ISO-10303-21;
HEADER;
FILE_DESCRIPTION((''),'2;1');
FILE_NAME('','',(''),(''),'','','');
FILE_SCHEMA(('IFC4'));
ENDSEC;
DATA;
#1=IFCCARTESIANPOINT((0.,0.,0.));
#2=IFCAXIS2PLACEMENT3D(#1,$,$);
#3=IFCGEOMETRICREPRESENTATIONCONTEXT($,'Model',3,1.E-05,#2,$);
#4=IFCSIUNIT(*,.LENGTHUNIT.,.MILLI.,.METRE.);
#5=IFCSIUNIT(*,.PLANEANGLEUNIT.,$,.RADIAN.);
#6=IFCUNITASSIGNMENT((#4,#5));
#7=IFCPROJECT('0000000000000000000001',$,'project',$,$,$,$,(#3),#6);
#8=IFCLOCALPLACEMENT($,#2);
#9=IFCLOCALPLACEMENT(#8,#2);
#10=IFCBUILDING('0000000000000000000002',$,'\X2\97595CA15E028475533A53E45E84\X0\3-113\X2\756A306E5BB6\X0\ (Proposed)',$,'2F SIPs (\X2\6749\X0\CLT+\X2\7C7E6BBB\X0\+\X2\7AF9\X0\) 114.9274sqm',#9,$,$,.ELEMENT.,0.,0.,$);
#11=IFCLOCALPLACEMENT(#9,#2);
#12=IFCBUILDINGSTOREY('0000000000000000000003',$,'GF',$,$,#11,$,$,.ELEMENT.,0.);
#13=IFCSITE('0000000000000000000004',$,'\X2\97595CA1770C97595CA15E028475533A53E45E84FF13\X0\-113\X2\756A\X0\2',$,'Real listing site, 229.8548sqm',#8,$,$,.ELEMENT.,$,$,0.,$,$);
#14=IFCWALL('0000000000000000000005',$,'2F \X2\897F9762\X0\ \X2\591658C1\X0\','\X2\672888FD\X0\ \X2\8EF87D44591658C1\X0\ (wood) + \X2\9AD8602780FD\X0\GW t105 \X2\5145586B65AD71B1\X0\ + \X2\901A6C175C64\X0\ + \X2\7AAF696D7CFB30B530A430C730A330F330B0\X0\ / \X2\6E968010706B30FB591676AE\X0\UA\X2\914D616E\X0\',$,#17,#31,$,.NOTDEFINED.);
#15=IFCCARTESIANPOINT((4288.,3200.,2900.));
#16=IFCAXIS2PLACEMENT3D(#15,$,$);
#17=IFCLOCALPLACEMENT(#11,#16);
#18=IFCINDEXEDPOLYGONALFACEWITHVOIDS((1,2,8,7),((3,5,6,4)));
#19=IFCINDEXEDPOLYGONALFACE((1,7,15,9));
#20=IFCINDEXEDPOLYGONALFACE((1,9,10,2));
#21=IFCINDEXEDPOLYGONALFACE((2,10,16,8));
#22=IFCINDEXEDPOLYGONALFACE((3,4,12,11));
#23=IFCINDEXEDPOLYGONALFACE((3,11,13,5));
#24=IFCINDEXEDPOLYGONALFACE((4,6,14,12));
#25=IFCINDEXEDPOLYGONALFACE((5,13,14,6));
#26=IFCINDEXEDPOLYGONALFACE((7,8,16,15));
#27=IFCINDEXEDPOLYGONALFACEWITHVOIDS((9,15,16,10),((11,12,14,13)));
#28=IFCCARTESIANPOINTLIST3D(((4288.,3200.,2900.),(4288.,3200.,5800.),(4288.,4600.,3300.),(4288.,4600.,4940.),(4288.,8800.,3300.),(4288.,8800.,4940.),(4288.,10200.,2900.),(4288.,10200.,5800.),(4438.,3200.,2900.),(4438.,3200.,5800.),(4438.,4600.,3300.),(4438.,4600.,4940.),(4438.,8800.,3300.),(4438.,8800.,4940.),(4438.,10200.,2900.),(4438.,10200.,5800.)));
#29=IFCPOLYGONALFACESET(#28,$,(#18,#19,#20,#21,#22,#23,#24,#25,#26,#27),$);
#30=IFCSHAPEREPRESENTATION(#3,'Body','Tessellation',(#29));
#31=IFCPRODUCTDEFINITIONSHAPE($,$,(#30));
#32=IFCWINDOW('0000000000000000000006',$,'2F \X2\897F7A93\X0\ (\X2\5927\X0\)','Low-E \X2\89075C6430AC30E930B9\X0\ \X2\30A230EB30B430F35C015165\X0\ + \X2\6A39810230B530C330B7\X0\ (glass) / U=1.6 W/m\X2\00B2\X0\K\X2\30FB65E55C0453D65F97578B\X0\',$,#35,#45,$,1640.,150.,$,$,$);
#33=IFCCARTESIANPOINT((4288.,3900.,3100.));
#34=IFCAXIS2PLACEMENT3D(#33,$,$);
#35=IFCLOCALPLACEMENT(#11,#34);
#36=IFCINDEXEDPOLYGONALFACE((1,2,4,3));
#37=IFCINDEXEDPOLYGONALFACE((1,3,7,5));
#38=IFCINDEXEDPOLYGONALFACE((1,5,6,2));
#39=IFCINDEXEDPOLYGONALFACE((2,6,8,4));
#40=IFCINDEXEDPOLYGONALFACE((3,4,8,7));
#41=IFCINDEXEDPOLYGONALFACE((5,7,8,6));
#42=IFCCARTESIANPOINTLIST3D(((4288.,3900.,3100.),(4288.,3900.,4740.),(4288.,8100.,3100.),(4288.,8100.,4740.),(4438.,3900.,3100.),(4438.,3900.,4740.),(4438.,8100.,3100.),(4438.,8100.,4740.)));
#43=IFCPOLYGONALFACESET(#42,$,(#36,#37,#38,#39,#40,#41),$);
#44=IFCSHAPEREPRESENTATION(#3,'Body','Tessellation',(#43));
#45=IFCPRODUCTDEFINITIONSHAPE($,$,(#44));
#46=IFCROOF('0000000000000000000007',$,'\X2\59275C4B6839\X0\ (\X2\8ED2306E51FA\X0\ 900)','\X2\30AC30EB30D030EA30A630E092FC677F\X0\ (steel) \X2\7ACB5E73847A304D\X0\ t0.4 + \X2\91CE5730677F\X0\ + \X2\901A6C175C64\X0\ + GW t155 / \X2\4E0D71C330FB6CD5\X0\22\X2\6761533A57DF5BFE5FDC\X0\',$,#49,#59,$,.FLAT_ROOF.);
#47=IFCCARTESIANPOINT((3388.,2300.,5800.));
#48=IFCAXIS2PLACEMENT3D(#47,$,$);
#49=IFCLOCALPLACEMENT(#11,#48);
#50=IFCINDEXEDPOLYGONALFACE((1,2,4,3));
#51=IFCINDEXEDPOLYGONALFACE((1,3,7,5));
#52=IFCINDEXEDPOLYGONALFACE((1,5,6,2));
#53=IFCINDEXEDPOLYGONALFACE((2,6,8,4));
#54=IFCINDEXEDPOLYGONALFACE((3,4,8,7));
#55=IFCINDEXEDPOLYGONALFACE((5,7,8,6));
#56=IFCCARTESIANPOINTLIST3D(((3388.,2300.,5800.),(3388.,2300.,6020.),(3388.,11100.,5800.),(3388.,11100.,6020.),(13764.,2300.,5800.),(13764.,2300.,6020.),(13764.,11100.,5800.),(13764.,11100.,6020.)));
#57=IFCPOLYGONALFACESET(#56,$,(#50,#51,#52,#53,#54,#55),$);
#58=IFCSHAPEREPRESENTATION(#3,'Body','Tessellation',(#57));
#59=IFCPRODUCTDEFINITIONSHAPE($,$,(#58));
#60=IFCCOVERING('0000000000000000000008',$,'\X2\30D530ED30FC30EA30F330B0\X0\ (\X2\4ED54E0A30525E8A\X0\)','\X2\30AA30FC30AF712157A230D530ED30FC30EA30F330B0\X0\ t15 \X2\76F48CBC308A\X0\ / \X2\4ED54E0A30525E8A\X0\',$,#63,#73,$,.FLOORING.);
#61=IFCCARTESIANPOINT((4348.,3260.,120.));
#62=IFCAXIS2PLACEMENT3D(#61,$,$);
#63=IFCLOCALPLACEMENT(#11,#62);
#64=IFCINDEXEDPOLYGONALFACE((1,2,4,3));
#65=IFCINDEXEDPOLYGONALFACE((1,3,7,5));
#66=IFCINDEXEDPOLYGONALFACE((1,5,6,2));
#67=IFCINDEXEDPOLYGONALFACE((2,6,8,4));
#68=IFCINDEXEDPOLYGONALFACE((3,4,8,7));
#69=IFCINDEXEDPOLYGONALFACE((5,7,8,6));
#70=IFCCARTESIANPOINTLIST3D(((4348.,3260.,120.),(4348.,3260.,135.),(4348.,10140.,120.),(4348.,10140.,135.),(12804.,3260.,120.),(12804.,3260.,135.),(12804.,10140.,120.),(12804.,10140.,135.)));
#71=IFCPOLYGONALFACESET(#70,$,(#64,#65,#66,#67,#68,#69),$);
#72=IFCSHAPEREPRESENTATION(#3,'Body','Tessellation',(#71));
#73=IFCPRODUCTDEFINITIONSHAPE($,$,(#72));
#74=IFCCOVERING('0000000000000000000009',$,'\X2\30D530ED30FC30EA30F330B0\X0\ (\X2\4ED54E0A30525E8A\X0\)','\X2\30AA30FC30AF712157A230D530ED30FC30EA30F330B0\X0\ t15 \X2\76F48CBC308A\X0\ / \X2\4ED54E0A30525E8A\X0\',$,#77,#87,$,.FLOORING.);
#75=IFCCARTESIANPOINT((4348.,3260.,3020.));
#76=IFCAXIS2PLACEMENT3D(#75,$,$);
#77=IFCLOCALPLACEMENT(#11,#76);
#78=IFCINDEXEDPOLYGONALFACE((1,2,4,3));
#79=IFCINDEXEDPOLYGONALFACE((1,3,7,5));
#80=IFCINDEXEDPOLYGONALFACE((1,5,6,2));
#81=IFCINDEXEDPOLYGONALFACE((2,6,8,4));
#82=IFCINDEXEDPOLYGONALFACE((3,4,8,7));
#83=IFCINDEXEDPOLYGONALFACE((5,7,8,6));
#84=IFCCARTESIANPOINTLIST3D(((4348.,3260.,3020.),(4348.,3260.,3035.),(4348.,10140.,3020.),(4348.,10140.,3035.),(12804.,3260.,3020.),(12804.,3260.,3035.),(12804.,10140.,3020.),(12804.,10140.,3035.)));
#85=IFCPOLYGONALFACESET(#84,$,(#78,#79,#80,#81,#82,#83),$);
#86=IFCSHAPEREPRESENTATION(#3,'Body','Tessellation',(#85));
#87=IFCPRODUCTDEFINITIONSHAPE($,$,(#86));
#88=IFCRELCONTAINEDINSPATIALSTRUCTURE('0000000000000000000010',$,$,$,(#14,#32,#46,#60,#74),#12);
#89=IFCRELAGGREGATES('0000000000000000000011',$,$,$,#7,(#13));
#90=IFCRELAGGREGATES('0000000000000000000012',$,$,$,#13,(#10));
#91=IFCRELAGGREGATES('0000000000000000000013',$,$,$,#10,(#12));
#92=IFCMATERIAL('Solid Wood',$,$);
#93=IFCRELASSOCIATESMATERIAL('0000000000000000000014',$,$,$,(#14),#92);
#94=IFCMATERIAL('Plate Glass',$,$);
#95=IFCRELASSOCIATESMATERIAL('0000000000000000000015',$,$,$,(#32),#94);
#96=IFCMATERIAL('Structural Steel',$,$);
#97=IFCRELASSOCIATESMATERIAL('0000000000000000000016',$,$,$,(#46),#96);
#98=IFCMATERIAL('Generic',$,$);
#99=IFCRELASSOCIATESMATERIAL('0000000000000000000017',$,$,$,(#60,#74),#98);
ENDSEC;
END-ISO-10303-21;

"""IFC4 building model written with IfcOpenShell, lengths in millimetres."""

from ifc_helpers import new_model, si_unit, frame, frame_2d, origin, place, context, project, spatial, rectangle, extrude, material, element, fill, save


model = new_model("IFC4")

# Units and contexts
model_context = context("Model", 3, precision=1e-05, world=origin())
ifc_project = project(units=[si_unit("LENGTHUNIT", "METRE", prefix="MILLI"), si_unit("PLANEANGLEUNIT", "RADIAN")], contexts=[model_context])

# Site, building, storey
site_placement = place(None, origin())
site = spatial("IfcSite", under=ifc_project, at=site_placement, Name="静岡県静岡市葵区古庄３-113番2", ObjectType="Real listing site, 229.8548sqm", CompositionType="ELEMENT", RefElevation=0.0)
building_placement = place(site_placement, origin())
building = spatial("IfcBuilding", under=site, at=building_placement, Name="静岡市葵区古庄3-113番の家 (Proposed)", ObjectType="2F SIPs (杉CLT+籾殻+竹) 114.9274sqm", CompositionType="ELEMENT", ElevationOfRefHeight=0.0, ElevationOfTerrain=0.0)
storey_placement = place(building_placement, origin())
storey = spatial("IfcBuildingStorey", under=building, at=storey_placement, Name="GF", CompositionType="ELEMENT", Elevation=0.0)

# Shared definitions
ifc_material_1 = material(Name="Solid Wood")

# Shared definitions
ifc_material_2 = material(Name="Plate Glass")

# Wall, opening, window
wall_1_placement = place(storey_placement, frame((4288.0, 3200.0, 2900.0)))
wall_1 = element("IfcWall", 1, at=wall_1_placement, inside=storey, material=ifc_material_1, Name="2F 西面 外壁", Description="木製 軸組外壁 (wood) + 高性能GW t105 充填断熱 + 通気層 + 窯業系サイディング / 準耐火・外皮UA配慮", PredefinedType="NOTDEFINED", context=model_context, shape_type="SweptSolid", body=[
    extrude(rectangle(XDim=150.0, YDim=7000.0, at=frame_2d((75.0, 3500.0))), frame((4288.0, 3200.0, 2900.0)), (0.0, 0.0, 1.0), 2900.0),
])
opening_1_placement = place(storey_placement, frame((4288.0, 3900.0, 3100.0)))
opening_1 = element("IfcOpeningElement", 2, at=opening_1_placement, cuts=wall_1, PredefinedType="NOTDEFINED", context=model_context, shape_type="SweptSolid", body=[
    extrude(rectangle(XDim=150.0, YDim=4200.0, at=frame_2d((75.0, 2100.0))), frame((4288.0, 3900.0, 3100.0)), (0.0, 0.0, 1.0), 1640.0),
])
window_1_placement = place(storey_placement, frame((4288.0, 3900.0, 3100.0)))
window_1 = element("IfcWindow", 3, at=window_1_placement, inside=storey, material=ifc_material_2, Name="2F 西窓 (大)", Description="Low-E 複層ガラス アルゴン封入 + 樹脂サッシ (glass) / U=1.6 W/m²K・日射取得型", OverallHeight=1640.0, OverallWidth=150.0, context=model_context, shape_type="SweptSolid", body=[
    extrude(rectangle(XDim=150.0, YDim=4200.0, at=frame_2d((75.0, 2100.0))), frame((4288.0, 3900.0, 3100.0)), (0.0, 0.0, 1.0), 1640.0),
])
fill(opening_1, window_1)

# Roof
ifc_material_3 = material(Name="Structural Steel")
roof_placement = place(storey_placement, frame((3388.0, 2300.0, 5800.0)))
element("IfcRoof", 4, at=roof_placement, inside=storey, material=ifc_material_3, Name="大屋根 (軒の出 900)", Description="ガルバリウム鋼板 (steel) 立平葺き t0.4 + 野地板 + 通気層 + GW t155 / 不燃・法22条区域対応", PredefinedType="FLAT_ROOF", context=model_context, shape_type="SweptSolid", body=[
    extrude(rectangle(XDim=10376.0, YDim=8800.0, at=frame_2d((5188.0, 4400.0))), frame((3388.0, 2300.0, 5800.0)), (0.0, 0.0, 1.0), 220.0),
])

# Coverings
ifc_material_4 = material(Name="Generic")
covering_1_placement = place(storey_placement, frame((4348.0, 3260.0, 120.0)))
element("IfcCovering", 5, at=covering_1_placement, inside=storey, material=ifc_material_4, Name="フローリング (仕上げ床)", Description="オーク無垢フローリング t15 直貼り / 仕上げ床", PredefinedType="FLOORING", context=model_context, shape_type="SweptSolid", body=[
    extrude(rectangle(XDim=8456.0, YDim=6880.0, at=frame_2d((4228.0, 3440.0))), frame((4348.0, 3260.0, 120.0)), (0.0, 0.0, 1.0), 15.0),
])
covering_2_placement = place(storey_placement, frame((4348.0, 3260.0, 3020.0)))
element("IfcCovering", 6, at=covering_2_placement, inside=storey, material=ifc_material_4, Name="フローリング (仕上げ床)", Description="オーク無垢フローリング t15 直貼り / 仕上げ床", PredefinedType="FLOORING", context=model_context, shape_type="SweptSolid", body=[
    extrude(rectangle(XDim=8456.0, YDim=6880.0, at=frame_2d((4228.0, 3440.0))), frame((4348.0, 3260.0, 3020.0)), (0.0, 0.0, 1.0), 15.0),
])

save(model, "model.ifc")
